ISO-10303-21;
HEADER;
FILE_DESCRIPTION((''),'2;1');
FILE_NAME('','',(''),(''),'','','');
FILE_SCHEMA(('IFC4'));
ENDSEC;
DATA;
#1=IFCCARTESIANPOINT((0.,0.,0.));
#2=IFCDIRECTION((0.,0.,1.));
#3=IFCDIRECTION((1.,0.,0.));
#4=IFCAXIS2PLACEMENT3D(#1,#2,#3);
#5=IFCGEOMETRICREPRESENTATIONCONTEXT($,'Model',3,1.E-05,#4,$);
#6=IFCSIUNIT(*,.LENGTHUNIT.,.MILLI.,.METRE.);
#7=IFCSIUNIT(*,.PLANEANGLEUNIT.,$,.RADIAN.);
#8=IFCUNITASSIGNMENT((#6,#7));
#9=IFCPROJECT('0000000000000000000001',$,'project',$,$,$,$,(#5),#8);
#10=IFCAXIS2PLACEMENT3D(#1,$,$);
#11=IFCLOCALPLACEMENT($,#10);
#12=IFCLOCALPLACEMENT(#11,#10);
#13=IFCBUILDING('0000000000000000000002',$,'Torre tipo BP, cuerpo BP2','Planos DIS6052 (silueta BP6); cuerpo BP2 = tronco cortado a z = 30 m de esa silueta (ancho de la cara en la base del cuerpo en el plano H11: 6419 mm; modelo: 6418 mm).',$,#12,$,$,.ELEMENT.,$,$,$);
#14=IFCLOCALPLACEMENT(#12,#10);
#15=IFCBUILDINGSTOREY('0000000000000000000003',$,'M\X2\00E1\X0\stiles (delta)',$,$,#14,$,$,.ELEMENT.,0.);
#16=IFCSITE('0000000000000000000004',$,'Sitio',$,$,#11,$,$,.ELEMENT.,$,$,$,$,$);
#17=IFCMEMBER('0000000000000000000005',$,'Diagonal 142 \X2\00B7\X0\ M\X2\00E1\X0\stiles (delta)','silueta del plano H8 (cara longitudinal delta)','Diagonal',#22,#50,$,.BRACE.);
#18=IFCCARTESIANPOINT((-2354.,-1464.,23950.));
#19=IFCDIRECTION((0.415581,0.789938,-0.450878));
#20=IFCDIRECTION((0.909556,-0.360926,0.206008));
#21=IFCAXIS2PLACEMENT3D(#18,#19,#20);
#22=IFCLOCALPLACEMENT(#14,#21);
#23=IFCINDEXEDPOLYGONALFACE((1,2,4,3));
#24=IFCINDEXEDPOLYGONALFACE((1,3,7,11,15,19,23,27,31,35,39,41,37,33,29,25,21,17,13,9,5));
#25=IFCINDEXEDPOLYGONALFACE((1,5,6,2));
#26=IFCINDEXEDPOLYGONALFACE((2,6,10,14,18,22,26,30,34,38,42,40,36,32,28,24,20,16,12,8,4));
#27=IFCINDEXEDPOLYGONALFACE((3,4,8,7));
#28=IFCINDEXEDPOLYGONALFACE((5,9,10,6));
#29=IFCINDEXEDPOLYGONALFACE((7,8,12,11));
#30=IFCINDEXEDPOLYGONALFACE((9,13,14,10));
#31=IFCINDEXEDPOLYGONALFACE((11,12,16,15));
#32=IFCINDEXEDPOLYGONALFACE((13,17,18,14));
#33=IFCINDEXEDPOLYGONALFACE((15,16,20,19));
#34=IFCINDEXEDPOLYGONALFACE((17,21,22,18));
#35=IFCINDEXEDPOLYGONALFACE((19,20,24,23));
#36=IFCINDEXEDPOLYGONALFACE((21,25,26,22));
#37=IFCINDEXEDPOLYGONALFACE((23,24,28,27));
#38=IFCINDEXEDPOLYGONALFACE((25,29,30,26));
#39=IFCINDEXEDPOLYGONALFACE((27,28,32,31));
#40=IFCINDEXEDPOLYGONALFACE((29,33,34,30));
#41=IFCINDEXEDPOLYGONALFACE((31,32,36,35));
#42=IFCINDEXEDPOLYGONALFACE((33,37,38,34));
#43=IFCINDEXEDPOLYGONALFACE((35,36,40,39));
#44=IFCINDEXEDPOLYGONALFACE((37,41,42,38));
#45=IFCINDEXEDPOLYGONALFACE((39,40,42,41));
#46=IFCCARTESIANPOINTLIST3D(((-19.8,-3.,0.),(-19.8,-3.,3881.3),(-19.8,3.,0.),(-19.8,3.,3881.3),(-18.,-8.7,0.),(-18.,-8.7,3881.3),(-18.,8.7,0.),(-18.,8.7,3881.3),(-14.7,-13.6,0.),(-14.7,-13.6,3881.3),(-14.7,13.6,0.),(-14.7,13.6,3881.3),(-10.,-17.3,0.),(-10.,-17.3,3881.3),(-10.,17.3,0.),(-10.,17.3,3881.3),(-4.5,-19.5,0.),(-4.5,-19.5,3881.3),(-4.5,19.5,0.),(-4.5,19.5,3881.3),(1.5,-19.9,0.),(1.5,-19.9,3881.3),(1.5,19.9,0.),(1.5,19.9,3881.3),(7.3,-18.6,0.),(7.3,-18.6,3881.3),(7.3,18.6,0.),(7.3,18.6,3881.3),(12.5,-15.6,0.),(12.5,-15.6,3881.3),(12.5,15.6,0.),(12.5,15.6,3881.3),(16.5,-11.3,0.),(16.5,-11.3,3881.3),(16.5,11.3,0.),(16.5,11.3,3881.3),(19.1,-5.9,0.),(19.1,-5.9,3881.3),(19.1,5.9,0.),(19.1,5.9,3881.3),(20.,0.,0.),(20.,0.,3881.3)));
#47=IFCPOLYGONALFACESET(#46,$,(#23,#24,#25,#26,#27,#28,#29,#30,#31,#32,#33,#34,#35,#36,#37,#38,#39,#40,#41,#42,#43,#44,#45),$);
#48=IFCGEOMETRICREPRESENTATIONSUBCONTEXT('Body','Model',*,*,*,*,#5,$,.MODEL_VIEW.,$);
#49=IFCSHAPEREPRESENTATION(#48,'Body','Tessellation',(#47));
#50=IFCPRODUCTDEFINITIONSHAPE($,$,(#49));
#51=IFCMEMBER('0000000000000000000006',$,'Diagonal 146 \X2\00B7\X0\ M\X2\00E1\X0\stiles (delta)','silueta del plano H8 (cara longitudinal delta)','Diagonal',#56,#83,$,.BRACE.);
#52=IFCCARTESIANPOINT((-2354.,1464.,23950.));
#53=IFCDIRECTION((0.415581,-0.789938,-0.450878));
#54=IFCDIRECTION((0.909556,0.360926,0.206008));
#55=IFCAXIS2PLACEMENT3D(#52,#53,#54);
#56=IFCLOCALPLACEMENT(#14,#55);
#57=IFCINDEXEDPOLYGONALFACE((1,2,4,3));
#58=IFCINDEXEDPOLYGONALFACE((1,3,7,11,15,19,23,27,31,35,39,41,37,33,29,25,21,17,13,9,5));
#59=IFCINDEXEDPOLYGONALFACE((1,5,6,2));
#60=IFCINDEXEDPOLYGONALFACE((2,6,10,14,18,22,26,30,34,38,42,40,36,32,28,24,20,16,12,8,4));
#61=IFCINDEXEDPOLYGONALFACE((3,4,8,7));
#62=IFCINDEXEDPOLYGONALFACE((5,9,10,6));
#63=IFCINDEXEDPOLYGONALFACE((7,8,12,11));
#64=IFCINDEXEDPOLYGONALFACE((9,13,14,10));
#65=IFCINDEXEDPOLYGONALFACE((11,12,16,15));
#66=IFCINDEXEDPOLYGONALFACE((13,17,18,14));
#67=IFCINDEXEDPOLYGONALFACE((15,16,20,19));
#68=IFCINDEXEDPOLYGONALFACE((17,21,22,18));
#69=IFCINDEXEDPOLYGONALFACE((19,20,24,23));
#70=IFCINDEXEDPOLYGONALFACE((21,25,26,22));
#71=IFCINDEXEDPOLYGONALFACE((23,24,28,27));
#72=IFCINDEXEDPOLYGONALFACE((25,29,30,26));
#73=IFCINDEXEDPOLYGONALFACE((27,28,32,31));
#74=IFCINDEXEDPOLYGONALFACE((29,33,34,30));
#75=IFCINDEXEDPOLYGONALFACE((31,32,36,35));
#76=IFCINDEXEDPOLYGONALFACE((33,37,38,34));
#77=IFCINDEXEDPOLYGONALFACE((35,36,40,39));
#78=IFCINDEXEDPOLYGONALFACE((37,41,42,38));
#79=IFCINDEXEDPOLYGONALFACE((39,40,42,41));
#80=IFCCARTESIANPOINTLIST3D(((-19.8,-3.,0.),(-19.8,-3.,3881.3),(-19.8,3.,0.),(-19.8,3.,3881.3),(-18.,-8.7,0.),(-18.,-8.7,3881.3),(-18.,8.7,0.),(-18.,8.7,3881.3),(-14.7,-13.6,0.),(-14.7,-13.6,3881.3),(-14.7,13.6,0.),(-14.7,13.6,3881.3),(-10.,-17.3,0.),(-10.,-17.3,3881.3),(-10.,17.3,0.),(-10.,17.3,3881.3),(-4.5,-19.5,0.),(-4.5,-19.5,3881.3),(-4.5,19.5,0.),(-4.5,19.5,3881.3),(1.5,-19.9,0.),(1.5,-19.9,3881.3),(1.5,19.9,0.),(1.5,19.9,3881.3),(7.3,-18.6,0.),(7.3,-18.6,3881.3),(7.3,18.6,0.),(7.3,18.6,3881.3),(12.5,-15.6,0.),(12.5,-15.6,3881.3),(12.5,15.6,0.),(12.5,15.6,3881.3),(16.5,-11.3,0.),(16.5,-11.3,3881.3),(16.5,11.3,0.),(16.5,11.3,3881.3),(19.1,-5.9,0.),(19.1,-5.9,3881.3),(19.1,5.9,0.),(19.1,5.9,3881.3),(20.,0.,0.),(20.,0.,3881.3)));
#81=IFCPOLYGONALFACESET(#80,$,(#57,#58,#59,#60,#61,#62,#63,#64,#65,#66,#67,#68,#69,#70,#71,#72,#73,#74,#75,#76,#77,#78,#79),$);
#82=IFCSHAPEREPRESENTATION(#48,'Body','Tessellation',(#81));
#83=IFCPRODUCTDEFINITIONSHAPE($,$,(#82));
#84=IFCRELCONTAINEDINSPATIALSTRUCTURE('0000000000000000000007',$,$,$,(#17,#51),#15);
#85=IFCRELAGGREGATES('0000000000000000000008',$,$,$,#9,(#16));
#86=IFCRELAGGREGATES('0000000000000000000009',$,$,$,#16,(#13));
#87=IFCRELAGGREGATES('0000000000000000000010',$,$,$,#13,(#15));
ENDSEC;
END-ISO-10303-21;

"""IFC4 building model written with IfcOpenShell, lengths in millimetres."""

from ifc_helpers import new_model, si_unit, frame, origin, origin_with_axes, place, context, subcontext, project, spatial, circle, extrude, element, save


model = new_model("IFC4")

# Units and contexts
model_context = context("Model", 3, precision=1e-05, world=origin_with_axes())
body_context = subcontext(model_context, "Body", "Model", "MODEL_VIEW")
ifc_project = project(units=[si_unit("LENGTHUNIT", "METRE", prefix="MILLI"), si_unit("PLANEANGLEUNIT", "RADIAN")], contexts=[model_context])

# Site, building, storey
site_placement = place(None, origin())
site = spatial("IfcSite", under=ifc_project, at=site_placement, Name="Sitio", CompositionType="ELEMENT")
building_placement = place(site_placement, origin())
building = spatial("IfcBuilding", under=site, at=building_placement, Name="Torre tipo BP, cuerpo BP2", Description="Planos DIS6052 (silueta BP6); cuerpo BP2 = tronco cortado a z = 30 m de esa silueta (ancho de la cara en la base del cuerpo en el plano H11: 6419 mm; modelo: 6418 mm).", CompositionType="ELEMENT")
storey_placement = place(building_placement, origin())
storey = spatial("IfcBuildingStorey", under=building, at=storey_placement, Name="Mástiles (delta)", CompositionType="ELEMENT", Elevation=0.0)

# Members
for number, where, z_axis, x_axis, name in (
    (1, (-2354.0, -1464.0, 23950.0), (0.415581, 0.789938, -0.450878), (0.909556, -0.360926, 0.206008), "Diagonal 142 · Mástiles (delta)"),
    (2, (-2354.0, 1464.0, 23950.0), (0.415581, -0.789938, -0.450878), (0.909556, 0.360926, 0.206008), "Diagonal 146 · Mástiles (delta)"),
):
    element("IfcMember", number, at=place(storey_placement, frame(where, z_axis=z_axis, x_axis=x_axis)), inside=storey, Name=name, Description="silueta del plano H8 (cara longitudinal delta)", ObjectType="Diagonal", PredefinedType="BRACE", context=body_context, shape_type="SweptSolid", body=[
        extrude(circle(Radius=20.0), None, (0.0, 0.0, 1.0), 3881.3),
    ])

save(model, "model.ifc")
